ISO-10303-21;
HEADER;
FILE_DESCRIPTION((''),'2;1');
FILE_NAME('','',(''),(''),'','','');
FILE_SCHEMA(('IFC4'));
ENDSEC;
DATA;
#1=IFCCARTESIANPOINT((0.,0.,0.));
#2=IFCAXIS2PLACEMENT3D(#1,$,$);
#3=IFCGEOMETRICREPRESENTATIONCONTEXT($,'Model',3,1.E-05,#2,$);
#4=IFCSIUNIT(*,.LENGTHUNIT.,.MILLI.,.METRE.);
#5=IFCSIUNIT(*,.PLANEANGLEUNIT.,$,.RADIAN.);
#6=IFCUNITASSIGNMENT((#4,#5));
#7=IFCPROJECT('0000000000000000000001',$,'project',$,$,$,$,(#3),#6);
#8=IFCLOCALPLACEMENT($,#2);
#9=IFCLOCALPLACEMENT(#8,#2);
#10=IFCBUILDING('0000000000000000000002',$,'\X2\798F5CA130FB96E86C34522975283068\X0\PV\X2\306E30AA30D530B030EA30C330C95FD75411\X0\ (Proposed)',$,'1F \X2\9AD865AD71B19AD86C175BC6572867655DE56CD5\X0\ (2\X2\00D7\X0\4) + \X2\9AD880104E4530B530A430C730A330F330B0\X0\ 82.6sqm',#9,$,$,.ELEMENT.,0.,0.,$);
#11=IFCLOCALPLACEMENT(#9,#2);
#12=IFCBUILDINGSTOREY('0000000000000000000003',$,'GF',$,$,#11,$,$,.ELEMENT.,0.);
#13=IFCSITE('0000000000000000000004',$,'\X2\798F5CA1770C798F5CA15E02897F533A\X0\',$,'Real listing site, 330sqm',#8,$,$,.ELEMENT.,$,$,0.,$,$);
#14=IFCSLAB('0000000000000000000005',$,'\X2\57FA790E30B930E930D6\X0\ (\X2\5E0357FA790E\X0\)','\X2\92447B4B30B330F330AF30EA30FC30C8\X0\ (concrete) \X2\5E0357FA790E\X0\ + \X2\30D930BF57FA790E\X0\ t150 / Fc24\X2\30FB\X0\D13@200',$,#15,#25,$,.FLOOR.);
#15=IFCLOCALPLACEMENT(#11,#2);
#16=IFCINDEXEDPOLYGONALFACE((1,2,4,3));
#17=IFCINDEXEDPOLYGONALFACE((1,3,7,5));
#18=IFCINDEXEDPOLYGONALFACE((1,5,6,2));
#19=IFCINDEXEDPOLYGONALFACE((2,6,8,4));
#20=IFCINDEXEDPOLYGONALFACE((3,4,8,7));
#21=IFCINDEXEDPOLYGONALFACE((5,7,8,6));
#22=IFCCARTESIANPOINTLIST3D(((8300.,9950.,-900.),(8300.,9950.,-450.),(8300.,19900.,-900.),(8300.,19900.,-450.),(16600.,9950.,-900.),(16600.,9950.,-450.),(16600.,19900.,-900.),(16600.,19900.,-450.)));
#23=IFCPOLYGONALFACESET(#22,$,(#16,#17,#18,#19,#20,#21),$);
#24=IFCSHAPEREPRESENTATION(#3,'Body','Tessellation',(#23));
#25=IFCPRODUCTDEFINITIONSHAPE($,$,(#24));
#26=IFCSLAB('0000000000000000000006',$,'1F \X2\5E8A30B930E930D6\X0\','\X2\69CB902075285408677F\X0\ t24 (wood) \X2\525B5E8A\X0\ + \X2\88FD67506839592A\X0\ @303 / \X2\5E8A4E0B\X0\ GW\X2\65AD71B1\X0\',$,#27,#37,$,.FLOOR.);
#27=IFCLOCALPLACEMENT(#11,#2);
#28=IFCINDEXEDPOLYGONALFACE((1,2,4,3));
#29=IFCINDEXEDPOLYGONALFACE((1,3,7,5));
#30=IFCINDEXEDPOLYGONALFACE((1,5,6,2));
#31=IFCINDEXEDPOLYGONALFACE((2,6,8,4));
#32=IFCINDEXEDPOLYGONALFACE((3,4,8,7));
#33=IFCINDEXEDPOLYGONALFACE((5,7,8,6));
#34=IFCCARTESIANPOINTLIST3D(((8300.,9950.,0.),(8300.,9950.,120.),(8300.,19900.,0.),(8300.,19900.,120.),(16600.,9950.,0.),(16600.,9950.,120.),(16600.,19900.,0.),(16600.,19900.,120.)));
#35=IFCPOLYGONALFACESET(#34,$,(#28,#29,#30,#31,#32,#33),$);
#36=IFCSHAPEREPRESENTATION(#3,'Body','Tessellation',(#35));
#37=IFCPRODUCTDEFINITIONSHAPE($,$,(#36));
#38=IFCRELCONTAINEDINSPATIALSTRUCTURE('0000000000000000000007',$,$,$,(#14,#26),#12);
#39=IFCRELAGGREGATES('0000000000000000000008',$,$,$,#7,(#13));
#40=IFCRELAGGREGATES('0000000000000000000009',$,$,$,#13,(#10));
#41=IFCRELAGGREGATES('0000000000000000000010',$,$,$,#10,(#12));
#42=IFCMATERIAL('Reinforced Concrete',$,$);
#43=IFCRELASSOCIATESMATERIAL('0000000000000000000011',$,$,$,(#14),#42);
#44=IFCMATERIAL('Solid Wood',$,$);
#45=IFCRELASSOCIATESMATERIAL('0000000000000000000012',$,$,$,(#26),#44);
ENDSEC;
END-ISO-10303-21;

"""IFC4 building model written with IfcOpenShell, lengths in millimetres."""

from ifc_helpers import new_model, si_unit, frame, frame_2d, origin, place, context, project, spatial, rectangle, extrude, material, element, save


model = new_model("IFC4")

# Units and contexts
model_context = context("Model", 3, precision=1e-05, world=origin())
ifc_project = project(units=[si_unit("LENGTHUNIT", "METRE", prefix="MILLI"), si_unit("PLANEANGLEUNIT", "RADIAN")], contexts=[model_context])

# Site, building, storey
site_placement = place(None, origin())
site = spatial("IfcSite", under=ifc_project, at=site_placement, Name="福岡県福岡市西区", ObjectType="Real listing site, 330sqm", CompositionType="ELEMENT", RefElevation=0.0)
building_placement = place(site_placement, origin())
building = spatial("IfcBuilding", under=site, at=building_placement, Name="福岡・雨水利用とPVのオフグリッド志向 (Proposed)", ObjectType="1F 高断熱高気密在来工法 (2×4) + 高耐久サイディング 82.6sqm", CompositionType="ELEMENT", ElevationOfRefHeight=0.0, ElevationOfTerrain=0.0)
storey_placement = place(building_placement, origin())
storey = spatial("IfcBuildingStorey", under=building, at=storey_placement, Name="GF", CompositionType="ELEMENT", Elevation=0.0)

# Shared definitions
ifc_material_1 = material(Name="Solid Wood")

# Slabs
ifc_material_2 = material(Name="Reinforced Concrete")
slab_1_placement = place(storey_placement, frame((4150.0, 4975.0, -450.0)))
element("IfcSlab", 1, at=slab_1_placement, inside=storey, material=ifc_material_2, Name="基礎スラブ (布基礎)", Description="鉄筋コンクリート (concrete) 布基礎 + ベタ基礎 t150 / Fc24・D13@200", PredefinedType="FLOOR", context=model_context, shape_type="SweptSolid", body=[
    extrude(rectangle(XDim=8300.0, YDim=9950.0, at=frame_2d((4150.0, 4975.0))), frame((4150.0, 4975.0, -450.0)), (0.0, 0.0, 1.0), 450.0),
])
slab_2_placement = place(storey_placement, frame((4150.0, 4975.0, 0.0)))
element("IfcSlab", 2, at=slab_2_placement, inside=storey, material=ifc_material_1, Name="1F 床スラブ", Description="構造用合板 t24 (wood) 剛床 + 製材根太 @303 / 床下 GW断熱", PredefinedType="FLOOR", context=model_context, shape_type="SweptSolid", body=[
    extrude(rectangle(XDim=8300.0, YDim=9950.0, at=frame_2d((4150.0, 4975.0))), frame((4150.0, 4975.0, 0.0)), (0.0, 0.0, 1.0), 120.0),
])

save(model, "model.ifc")
